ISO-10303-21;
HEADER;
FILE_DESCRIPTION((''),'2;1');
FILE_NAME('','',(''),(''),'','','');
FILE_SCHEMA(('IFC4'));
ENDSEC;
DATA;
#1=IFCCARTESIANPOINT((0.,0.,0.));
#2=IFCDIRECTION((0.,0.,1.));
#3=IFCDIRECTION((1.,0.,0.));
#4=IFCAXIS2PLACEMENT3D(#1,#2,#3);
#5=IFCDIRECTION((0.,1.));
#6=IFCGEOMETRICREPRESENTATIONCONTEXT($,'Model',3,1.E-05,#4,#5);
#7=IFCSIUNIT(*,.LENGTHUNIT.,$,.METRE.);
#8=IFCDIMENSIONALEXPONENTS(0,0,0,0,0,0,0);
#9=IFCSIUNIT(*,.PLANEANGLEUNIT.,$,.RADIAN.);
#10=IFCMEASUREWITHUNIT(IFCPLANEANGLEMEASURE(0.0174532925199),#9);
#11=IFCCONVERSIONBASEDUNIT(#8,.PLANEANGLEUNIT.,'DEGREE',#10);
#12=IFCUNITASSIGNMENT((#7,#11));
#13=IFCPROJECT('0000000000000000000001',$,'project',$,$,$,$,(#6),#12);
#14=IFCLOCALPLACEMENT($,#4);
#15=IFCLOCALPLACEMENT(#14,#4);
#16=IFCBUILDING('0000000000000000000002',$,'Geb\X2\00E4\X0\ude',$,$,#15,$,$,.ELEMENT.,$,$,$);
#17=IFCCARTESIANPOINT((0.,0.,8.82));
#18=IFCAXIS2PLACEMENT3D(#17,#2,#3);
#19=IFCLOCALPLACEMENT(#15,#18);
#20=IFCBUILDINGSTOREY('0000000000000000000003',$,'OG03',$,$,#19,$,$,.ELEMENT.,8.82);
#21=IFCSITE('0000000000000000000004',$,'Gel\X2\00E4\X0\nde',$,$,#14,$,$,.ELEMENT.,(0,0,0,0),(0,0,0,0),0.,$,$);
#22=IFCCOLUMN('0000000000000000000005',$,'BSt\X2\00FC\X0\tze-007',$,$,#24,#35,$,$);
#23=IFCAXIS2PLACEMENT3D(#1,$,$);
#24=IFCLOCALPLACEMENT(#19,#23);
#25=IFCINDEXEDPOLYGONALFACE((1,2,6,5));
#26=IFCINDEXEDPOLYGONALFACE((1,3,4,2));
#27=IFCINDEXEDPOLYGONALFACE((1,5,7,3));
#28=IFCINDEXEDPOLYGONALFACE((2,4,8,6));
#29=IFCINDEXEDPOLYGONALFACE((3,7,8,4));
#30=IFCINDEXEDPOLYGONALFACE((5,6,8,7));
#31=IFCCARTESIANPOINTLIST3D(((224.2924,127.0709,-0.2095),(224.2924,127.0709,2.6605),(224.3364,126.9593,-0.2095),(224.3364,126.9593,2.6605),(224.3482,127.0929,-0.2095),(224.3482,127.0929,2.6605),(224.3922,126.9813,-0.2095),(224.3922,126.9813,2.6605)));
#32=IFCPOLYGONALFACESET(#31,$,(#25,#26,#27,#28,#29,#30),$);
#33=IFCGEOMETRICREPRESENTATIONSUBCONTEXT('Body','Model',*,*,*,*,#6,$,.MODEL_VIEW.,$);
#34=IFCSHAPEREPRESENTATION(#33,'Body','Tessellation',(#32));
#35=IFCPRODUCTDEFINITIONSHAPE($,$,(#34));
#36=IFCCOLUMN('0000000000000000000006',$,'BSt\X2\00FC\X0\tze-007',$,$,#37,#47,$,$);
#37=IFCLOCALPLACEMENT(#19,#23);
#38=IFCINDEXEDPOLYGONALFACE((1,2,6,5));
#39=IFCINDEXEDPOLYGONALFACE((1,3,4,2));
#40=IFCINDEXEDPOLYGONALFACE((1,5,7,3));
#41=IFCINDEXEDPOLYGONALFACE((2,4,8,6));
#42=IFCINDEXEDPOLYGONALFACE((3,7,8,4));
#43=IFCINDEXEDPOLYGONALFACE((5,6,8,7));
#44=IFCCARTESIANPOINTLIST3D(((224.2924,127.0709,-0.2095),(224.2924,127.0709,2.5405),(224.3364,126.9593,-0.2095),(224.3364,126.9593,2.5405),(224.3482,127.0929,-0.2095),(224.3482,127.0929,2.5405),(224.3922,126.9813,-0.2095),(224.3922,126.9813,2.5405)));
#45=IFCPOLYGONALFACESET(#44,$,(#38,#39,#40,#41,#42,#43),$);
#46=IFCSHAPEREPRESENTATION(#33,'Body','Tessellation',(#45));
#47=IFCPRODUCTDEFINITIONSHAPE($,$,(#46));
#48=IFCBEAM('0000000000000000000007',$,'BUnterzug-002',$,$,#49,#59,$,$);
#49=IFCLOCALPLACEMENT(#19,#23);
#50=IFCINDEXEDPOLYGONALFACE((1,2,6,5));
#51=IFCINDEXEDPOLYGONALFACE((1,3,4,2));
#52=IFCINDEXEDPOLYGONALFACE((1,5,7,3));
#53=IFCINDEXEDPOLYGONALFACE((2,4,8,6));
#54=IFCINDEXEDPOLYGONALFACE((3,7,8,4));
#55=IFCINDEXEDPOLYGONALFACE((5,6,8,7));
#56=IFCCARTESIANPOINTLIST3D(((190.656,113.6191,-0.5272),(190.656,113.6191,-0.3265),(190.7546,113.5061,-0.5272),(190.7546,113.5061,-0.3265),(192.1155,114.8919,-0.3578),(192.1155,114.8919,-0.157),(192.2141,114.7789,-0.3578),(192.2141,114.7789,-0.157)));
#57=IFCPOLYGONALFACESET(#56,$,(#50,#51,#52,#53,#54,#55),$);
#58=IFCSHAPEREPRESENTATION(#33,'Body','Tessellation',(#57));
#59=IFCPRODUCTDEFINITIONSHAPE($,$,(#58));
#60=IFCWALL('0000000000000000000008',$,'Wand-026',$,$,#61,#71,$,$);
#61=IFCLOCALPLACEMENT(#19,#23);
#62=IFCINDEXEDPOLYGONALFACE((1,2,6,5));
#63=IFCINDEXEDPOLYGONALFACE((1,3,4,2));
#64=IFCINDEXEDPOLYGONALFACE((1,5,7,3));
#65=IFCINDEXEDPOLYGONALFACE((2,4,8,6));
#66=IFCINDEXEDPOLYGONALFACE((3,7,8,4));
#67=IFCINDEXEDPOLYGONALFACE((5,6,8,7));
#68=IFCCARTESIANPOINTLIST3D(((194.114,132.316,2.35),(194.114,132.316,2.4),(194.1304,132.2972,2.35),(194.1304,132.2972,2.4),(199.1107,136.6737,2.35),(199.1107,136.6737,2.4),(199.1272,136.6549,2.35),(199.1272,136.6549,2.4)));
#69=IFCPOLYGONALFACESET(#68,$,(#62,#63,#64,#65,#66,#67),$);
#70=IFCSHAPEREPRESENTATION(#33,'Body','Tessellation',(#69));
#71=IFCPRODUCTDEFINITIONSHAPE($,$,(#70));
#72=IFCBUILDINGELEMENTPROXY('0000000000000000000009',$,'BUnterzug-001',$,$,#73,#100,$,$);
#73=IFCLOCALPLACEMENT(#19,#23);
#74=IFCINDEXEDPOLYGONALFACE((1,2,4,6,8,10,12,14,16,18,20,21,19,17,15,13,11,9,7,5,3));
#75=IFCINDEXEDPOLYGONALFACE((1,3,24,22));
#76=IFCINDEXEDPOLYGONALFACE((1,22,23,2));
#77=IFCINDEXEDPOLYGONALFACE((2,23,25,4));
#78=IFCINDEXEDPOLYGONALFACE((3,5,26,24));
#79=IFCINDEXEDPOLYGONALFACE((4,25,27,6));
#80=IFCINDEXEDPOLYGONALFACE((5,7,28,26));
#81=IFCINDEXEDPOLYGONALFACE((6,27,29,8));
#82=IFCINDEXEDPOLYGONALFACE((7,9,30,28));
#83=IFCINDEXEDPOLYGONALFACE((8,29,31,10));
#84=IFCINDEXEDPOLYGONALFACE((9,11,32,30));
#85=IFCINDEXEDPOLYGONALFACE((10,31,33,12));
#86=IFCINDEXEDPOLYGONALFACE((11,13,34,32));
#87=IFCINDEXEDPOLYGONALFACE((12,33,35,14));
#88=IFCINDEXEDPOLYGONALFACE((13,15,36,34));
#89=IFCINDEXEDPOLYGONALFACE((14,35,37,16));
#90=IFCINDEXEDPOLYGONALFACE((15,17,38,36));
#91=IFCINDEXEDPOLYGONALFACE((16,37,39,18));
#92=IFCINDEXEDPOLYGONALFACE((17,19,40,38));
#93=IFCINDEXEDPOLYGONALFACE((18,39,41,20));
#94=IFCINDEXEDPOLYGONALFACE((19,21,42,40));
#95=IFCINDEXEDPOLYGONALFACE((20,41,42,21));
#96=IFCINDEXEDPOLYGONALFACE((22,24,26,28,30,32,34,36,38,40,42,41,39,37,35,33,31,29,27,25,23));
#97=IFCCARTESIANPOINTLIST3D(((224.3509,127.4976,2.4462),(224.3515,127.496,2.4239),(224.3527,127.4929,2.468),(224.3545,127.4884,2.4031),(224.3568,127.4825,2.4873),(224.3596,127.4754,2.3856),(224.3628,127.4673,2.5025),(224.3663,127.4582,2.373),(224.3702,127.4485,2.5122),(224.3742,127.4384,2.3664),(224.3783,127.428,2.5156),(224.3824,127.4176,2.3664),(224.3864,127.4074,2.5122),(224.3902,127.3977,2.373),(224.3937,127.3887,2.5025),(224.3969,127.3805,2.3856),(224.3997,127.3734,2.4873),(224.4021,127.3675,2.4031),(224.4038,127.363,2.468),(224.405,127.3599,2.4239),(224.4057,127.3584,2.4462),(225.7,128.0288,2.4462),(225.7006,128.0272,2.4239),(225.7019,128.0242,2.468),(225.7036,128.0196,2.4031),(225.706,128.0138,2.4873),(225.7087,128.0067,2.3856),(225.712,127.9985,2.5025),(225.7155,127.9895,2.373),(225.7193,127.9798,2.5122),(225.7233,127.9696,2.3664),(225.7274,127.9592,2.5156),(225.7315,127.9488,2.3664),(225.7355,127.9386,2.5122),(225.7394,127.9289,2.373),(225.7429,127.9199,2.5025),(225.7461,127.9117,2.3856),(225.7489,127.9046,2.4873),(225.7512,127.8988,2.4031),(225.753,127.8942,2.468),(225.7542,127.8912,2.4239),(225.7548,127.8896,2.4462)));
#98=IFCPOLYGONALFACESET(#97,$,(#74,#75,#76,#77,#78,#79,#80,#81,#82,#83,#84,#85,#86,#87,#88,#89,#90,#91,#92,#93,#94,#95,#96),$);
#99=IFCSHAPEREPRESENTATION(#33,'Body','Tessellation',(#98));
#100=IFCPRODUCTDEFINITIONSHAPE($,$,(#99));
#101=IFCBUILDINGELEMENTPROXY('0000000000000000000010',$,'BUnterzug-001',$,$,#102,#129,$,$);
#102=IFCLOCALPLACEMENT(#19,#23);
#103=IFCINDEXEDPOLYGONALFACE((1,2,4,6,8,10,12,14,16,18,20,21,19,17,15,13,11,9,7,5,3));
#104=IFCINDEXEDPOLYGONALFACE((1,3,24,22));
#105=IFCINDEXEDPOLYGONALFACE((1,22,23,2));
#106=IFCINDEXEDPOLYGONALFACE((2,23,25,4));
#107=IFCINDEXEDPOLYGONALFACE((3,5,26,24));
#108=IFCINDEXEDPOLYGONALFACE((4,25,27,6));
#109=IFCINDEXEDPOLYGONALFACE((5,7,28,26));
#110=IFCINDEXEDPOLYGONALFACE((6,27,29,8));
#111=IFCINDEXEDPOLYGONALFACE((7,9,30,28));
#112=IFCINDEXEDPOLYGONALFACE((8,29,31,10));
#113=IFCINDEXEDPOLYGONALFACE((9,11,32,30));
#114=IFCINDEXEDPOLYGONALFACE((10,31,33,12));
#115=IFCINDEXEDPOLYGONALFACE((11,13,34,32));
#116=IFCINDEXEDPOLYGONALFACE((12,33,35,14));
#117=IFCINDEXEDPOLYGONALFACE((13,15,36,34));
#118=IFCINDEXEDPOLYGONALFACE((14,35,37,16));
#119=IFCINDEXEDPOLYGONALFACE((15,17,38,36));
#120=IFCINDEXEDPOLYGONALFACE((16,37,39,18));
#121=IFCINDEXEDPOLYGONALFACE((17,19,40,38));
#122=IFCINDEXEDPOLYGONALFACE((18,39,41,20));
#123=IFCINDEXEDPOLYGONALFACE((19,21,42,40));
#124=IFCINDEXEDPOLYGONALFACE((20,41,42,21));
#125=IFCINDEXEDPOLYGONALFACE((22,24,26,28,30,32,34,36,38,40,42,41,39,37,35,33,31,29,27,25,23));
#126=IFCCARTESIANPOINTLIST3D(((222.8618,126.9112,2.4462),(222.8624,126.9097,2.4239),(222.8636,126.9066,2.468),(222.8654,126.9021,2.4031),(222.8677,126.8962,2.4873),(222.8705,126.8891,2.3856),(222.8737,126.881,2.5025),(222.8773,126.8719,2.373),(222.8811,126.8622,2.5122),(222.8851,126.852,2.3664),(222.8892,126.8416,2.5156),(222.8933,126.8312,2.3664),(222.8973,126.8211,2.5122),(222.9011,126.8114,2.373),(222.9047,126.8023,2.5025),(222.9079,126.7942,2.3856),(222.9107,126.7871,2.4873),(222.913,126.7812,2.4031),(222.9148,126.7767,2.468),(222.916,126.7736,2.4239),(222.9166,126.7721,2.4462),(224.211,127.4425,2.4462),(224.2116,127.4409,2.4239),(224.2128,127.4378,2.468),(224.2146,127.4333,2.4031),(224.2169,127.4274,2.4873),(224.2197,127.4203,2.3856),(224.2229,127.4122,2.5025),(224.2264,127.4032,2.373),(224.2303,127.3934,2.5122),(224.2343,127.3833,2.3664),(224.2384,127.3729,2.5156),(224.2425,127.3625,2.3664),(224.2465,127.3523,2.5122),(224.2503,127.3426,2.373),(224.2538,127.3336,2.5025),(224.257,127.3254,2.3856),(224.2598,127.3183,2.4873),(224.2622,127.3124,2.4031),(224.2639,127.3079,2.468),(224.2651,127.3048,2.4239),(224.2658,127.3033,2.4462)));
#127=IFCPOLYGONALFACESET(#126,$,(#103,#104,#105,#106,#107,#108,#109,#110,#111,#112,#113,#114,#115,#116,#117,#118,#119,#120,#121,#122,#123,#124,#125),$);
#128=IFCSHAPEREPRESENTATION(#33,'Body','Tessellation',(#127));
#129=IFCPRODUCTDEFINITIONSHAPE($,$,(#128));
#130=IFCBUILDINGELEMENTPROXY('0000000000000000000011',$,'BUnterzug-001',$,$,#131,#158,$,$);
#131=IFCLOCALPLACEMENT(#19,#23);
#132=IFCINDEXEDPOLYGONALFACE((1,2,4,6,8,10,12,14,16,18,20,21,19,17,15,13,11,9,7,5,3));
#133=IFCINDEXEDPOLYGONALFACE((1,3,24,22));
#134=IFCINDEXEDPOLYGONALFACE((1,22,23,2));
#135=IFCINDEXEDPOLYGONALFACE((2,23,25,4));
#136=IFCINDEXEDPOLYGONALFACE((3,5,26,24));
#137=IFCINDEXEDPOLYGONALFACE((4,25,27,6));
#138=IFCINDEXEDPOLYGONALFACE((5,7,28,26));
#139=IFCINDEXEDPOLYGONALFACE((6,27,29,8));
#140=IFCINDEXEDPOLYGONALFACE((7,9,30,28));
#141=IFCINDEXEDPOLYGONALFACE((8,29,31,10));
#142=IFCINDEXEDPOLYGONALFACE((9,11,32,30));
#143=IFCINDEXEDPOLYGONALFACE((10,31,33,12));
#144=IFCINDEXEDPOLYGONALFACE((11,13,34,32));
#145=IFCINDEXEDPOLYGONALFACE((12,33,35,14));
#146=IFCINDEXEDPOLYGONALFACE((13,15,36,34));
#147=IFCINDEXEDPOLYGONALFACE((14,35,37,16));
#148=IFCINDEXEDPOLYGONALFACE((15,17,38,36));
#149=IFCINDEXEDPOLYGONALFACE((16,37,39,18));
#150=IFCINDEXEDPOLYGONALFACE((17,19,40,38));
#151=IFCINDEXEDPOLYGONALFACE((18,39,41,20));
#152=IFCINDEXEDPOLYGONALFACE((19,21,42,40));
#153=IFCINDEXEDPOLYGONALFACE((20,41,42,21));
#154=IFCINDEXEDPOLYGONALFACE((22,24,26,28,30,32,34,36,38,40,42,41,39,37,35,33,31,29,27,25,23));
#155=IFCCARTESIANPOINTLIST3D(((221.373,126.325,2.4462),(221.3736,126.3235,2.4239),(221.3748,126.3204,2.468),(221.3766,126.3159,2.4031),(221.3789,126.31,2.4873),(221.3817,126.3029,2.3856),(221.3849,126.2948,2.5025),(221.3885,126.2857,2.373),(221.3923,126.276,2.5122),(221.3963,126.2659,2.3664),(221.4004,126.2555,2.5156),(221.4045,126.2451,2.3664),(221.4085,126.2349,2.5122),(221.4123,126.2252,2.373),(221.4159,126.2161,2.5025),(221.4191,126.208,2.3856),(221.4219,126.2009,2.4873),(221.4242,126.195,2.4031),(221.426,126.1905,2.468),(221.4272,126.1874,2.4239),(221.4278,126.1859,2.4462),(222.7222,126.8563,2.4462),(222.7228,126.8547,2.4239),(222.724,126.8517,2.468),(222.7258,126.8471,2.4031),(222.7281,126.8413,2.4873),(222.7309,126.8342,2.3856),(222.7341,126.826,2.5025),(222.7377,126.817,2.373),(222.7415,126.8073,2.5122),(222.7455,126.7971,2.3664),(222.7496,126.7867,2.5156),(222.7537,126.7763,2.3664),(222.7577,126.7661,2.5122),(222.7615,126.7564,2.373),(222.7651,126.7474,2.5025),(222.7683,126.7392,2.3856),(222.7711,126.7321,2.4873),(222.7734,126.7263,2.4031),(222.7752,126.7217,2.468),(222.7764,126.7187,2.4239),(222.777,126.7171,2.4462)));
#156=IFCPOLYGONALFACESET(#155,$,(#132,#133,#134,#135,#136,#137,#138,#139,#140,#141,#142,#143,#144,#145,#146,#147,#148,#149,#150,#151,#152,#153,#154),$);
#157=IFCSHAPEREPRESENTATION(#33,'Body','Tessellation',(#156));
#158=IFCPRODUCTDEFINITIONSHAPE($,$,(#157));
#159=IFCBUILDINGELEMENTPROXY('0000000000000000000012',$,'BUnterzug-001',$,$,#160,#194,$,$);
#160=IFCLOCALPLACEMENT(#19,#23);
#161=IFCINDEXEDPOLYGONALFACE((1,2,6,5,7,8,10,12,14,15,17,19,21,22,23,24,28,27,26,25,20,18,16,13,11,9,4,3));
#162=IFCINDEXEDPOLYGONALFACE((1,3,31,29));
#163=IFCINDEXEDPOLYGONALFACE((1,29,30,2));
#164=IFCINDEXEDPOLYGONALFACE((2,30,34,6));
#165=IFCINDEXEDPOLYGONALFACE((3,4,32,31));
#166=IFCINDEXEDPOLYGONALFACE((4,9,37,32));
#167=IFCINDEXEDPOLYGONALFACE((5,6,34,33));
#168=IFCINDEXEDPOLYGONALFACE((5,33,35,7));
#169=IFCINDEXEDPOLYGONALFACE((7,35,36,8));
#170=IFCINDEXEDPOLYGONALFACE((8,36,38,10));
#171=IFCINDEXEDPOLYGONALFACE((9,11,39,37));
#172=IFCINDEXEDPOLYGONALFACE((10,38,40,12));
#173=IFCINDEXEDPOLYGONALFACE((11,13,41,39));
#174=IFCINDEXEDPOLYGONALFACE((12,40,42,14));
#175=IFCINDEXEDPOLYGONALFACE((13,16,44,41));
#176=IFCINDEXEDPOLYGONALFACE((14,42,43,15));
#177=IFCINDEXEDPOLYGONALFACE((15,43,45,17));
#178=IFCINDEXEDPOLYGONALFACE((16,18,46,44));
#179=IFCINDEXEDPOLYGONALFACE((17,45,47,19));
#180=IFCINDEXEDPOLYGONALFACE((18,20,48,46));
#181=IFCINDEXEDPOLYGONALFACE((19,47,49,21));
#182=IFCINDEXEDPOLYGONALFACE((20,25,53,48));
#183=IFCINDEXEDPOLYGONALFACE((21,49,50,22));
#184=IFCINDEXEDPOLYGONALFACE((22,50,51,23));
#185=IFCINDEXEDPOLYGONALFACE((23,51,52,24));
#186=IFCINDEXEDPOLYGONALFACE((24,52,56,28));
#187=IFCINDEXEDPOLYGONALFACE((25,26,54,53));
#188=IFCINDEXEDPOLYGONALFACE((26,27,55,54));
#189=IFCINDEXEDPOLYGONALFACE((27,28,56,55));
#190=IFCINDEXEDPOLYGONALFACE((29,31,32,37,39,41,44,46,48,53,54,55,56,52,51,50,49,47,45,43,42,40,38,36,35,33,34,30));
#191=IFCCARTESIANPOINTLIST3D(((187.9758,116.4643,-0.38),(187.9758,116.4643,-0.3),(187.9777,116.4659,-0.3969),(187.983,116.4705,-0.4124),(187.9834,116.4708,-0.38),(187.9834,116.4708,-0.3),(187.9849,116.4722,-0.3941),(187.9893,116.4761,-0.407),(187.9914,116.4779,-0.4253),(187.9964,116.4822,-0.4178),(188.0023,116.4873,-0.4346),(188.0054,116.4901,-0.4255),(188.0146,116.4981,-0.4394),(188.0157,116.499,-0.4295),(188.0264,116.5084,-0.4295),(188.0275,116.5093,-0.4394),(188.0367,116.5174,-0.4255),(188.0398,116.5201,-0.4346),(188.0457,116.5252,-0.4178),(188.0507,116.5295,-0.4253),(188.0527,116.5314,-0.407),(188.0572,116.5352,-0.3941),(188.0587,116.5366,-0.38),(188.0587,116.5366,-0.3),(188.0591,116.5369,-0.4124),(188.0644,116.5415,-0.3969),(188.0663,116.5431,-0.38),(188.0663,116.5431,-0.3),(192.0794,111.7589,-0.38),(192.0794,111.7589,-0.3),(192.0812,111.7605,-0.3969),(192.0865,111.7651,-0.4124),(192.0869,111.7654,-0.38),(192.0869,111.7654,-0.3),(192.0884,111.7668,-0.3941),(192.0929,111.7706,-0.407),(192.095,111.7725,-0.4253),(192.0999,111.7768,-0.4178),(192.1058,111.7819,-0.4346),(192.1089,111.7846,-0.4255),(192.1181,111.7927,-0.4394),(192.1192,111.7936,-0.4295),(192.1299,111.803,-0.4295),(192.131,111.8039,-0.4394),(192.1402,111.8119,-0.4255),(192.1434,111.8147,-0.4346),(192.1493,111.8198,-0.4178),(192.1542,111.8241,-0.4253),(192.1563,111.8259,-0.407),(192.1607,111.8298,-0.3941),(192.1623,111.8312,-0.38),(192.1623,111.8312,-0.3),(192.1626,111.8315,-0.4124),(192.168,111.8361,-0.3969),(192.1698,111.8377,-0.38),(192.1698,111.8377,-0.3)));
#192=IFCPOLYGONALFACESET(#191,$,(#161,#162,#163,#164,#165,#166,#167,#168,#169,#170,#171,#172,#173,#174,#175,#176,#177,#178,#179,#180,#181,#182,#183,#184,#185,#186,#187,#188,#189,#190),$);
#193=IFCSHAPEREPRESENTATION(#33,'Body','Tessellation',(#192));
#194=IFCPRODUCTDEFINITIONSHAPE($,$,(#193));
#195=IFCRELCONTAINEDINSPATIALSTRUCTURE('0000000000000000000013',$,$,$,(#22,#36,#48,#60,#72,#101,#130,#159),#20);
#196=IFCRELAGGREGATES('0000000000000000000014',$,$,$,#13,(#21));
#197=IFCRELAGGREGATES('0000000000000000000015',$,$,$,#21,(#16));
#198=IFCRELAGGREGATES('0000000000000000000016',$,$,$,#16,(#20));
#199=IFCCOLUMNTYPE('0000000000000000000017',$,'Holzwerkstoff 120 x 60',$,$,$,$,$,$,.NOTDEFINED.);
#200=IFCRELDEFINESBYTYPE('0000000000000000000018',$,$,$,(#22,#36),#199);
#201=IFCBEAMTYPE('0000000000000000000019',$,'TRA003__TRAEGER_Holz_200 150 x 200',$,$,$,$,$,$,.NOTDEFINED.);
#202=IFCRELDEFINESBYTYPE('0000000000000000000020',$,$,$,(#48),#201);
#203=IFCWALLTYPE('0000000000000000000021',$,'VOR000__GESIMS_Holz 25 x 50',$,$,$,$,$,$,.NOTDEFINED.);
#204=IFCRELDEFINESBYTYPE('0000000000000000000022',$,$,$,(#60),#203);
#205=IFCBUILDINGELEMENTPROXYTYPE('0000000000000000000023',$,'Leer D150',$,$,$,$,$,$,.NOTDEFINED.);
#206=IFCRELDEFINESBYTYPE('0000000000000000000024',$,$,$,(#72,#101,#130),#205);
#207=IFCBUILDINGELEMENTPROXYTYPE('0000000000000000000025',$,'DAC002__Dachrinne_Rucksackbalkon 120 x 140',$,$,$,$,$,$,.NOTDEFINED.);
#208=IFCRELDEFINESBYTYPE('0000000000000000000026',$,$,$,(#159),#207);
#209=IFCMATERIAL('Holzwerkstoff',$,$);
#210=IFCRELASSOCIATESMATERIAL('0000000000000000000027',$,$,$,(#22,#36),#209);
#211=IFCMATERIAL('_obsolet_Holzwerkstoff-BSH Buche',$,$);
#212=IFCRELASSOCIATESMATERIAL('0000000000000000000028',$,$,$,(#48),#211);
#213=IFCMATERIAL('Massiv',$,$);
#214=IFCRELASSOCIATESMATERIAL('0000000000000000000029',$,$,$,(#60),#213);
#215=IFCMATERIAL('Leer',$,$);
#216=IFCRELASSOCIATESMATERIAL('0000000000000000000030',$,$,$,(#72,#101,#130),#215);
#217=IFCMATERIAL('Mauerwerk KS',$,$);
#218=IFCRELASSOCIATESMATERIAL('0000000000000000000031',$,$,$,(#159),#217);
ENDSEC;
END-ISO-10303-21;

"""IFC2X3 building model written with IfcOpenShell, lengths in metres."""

from ifc_helpers import new_model, entity, si_unit, converted_unit, point, direction, frame, frame_2d, origin_with_axes, origin_2d_with_axis, place, context, subcontext, project, spatial, polyline, circle_curve, parameter, trimmed, segment, composite_curve, rectangle, circle, outline, extrude, clip, halfspace, material, type_object, element, save


model = new_model("IFC2X3")

# Units and contexts
model_context = context("Model", 3, precision=1e-05, world=origin_with_axes(), true_north=direction((0.0, 1.0)))
body_context = subcontext(model_context, "Body", "Model", "MODEL_VIEW")
ifc_project = project(units=[si_unit("LENGTHUNIT", "METRE"), converted_unit("PLANEANGLEUNIT", "DEGREE", entity("IfcPlaneAngleMeasure", 0.0174532925199), si_unit("PLANEANGLEUNIT", "RADIAN"), dimensions=[0, 0, 0, 0, 0, 0, 0])], contexts=[model_context])

# Site, building, storey
site_placement = place(None, origin_with_axes())
site = spatial("IfcSite", under=ifc_project, at=site_placement, Name="Gelände", CompositionType="ELEMENT", RefLatitude=(0, 0, 0, 0), RefLongitude=(0, 0, 0, 0), RefElevation=0.0)
building_placement = place(site_placement, origin_with_axes())
building = spatial("IfcBuilding", under=site, at=building_placement, Name="Gebäude", CompositionType="ELEMENT")
storey_placement = place(building_placement, frame((0.0, 0.0, 8.82), z_axis=(0.0, 0.0, 1.0), x_axis=(1.0, 0.0, 0.0)))
storey = spatial("IfcBuildingStorey", under=building, at=storey_placement, Name="OG03", CompositionType="ELEMENT", Elevation=8.82)

# Columns
ifc_material_1 = material(Name="Holzwerkstoff")
column_type_1 = type_object("IfcColumnType", Name="Holzwerkstoff 120 x 60", PredefinedType="NOTDEFINED")
column_1_placement = place(storey_placement, frame((224.3423, 127.0261, -0.2095), z_axis=(0.0, 0.0, 1.0), x_axis=(0.366369, -0.93047, 0.0)))
element("IfcColumn", 1, at=column_1_placement, inside=storey, type_object=column_type_1, material=ifc_material_1, Name="BStütze-007", context=body_context, shape_type="SweptSolid", body=[
    extrude(rectangle(XDim=0.12, YDim=0.06, at=origin_2d_with_axis()), origin_with_axes(), (0.0, 0.0, 1.0), 2.87),
])
column_2_placement = place(storey_placement, frame((224.3423, 127.0261, -0.2095), z_axis=(0.0, 0.0, 1.0), x_axis=(0.366369, -0.93047, 0.0)))
element("IfcColumn", 2, at=column_2_placement, inside=storey, type_object=column_type_1, material=ifc_material_1, Name="BStütze-007", context=body_context, shape_type="SweptSolid", body=[
    extrude(rectangle(XDim=0.12, YDim=0.06, at=origin_2d_with_axis()), origin_with_axes(), (0.0, 0.0, 1.0), 2.75),
])

# Beam
ifc_material_2 = material(Name="_obsolet_Holzwerkstoff-BSH Buche")
beam_type = type_object("IfcBeamType", Name="TRA003__TRAEGER_Holz_200 150 x 200", PredefinedType="NOTDEFINED")
beam_placement = place(storey_placement, frame((190.7053, 113.5626, -0.4268), z_axis=(0.0, 0.0, 1.0), x_axis=(0.657268, -0.753657, 0.0)))
element("IfcBeam", 3, at=beam_placement, inside=storey, type_object=beam_type, material=ifc_material_2, Name="BUnterzug-002", context=body_context, shape_type="Clipping", body=[
    clip(clip(extrude(outline(polyline([(-0.075, -0.1), (0.075, -0.1), (0.075, 0.1), (-0.075, 0.1), (-0.075, -0.1)])), frame((0.0, 1.9612, 0.1716), z_axis=(0.0, 0.996195, 0.087156), x_axis=(-1.0, 0.0, 0.0)), (0.0, 0.0, -1.0), 1.9934), halfspace(frame((0.0, 0.0, 0.0), z_axis=(0.0, 1.0, 0.0), x_axis=(0.0, 0.0, 1.0)), True)), halfspace(frame((0.0, 1.9365, 0.0), z_axis=(0.0, -1.0, 0.0), x_axis=(0.0, 0.0, -1.0)), True)),
])

# Wall
ifc_material_3 = material(Name="Massiv")
wall_type = type_object("IfcWallType", Name="VOR000__GESIMS_Holz 25 x 50", PredefinedType="NOTDEFINED")
wall_placement = place(storey_placement, frame((199.1272, 136.6549, 2.375), z_axis=(0.0, 0.0, 1.0), x_axis=(-0.753657, -0.657268, 0.0)))
element("IfcWall", 4, at=wall_placement, inside=storey, type_object=wall_type, material=ifc_material_3, Name="Wand-026", context=body_context, shape_type="SweptSolid", body=[
    extrude(outline(polyline([(0.0, -0.025), (0.0, 0.025), (-0.025, 0.025), (-0.025, -0.025), (0.0, -0.025)])), frame((0.0, 0.0, 0.0), z_axis=(1.0, 0.0, 0.0), x_axis=(0.0, 1.0, 0.0)), (0.0, 0.0, 1.0), 6.63),
])

# Building element proxies
ifc_material_4 = material(Name="Leer")
building_element_proxy_type_1 = type_object("IfcBuildingElementProxyType", Name="Leer D150", PredefinedType="NOTDEFINED")
for number, where, z_axis, x_axis, name in (
    (5, (224.3783, 127.428, 2.5156), (0.0, 0.0, 1.0), (0.366369, -0.93047, 0.0), "BUnterzug-001"),
    (6, (222.8892, 126.8416, 2.5156), (0.0, 0.0, 1.0), (0.366369, -0.93047, 0.0), "BUnterzug-001"),
    (7, (221.4004, 126.2555, 2.5156), (0.0, 0.0, 1.0), (0.366369, -0.93047, 0.0), "BUnterzug-001"),
):
    element("IfcBuildingElementProxy", number, at=place(storey_placement, frame(where, z_axis=z_axis, x_axis=x_axis)), inside=storey, type_object=building_element_proxy_type_1, material=ifc_material_4, Name=name, context=body_context, shape_type="SweptSolid", body=[
        extrude(circle(Radius=0.075, at=frame_2d((-0.075, 0.0), x_axis=(1.0, 0.0))), frame((0.0, 0.0, 0.0), z_axis=(0.0, 1.0, 0.0), x_axis=(0.0, 0.0, 1.0)), (0.0, 0.0, 1.0), 1.45),
    ])
ifc_material_5 = material(Name="Mauerwerk KS")
building_element_proxy_type_2 = type_object("IfcBuildingElementProxyType", Name="DAC002__Dachrinne_Rucksackbalkon 120 x 140", PredefinedType="NOTDEFINED")
proxy_1_placement = place(storey_placement, frame((192.1698, 111.8377, -0.3), z_axis=(0.0, 0.0, 1.0), x_axis=(0.753663, 0.657261, 0.0)))
element("IfcBuildingElementProxy", 8, at=proxy_1_placement, inside=storey, type_object=building_element_proxy_type_2, material=ifc_material_5, Name="BUnterzug-001", context=body_context, shape_type="SweptSolid", body=[
    extrude(outline(composite_curve([segment(polyline([(-0.12, 0.0), (-0.12, -0.08)]), True, "CONTINUOUS"), segment(trimmed(circle_curve(frame_2d((-0.06, -0.08), x_axis=(-1.0, 0.0)), 0.06), [point((-0.12, -0.08)), parameter(0.0)], [point((0.0, -0.08)), parameter(180.0)], True, "CARTESIAN"), True, "CONTINUOUS"), segment(polyline([(0.0, -0.08), (0.0, 0.0), (-0.01, 0.0), (-0.01, -0.08)]), True, "CONTINUOUS"), segment(trimmed(circle_curve(frame_2d((-0.06, -0.08), x_axis=(-1.0, 0.0)), 0.05), [point((-0.01, -0.08)), parameter(180.0)], [point((-0.11, -0.08)), parameter(0.0)], False, "CARTESIAN"), True, "CONTINUOUS"), segment(polyline([(-0.11, -0.08), (-0.11, 0.0), (-0.12, 0.0)]), True, "CONTINUOUS")], self_intersect=False)), frame((0.0, 6.2434, 0.0), z_axis=(0.0, -1.0, 0.0), x_axis=(1.0, 0.0, 0.0)), (0.0, 0.0, 1.0), 6.2434),
])

save(model, "model.ifc")
